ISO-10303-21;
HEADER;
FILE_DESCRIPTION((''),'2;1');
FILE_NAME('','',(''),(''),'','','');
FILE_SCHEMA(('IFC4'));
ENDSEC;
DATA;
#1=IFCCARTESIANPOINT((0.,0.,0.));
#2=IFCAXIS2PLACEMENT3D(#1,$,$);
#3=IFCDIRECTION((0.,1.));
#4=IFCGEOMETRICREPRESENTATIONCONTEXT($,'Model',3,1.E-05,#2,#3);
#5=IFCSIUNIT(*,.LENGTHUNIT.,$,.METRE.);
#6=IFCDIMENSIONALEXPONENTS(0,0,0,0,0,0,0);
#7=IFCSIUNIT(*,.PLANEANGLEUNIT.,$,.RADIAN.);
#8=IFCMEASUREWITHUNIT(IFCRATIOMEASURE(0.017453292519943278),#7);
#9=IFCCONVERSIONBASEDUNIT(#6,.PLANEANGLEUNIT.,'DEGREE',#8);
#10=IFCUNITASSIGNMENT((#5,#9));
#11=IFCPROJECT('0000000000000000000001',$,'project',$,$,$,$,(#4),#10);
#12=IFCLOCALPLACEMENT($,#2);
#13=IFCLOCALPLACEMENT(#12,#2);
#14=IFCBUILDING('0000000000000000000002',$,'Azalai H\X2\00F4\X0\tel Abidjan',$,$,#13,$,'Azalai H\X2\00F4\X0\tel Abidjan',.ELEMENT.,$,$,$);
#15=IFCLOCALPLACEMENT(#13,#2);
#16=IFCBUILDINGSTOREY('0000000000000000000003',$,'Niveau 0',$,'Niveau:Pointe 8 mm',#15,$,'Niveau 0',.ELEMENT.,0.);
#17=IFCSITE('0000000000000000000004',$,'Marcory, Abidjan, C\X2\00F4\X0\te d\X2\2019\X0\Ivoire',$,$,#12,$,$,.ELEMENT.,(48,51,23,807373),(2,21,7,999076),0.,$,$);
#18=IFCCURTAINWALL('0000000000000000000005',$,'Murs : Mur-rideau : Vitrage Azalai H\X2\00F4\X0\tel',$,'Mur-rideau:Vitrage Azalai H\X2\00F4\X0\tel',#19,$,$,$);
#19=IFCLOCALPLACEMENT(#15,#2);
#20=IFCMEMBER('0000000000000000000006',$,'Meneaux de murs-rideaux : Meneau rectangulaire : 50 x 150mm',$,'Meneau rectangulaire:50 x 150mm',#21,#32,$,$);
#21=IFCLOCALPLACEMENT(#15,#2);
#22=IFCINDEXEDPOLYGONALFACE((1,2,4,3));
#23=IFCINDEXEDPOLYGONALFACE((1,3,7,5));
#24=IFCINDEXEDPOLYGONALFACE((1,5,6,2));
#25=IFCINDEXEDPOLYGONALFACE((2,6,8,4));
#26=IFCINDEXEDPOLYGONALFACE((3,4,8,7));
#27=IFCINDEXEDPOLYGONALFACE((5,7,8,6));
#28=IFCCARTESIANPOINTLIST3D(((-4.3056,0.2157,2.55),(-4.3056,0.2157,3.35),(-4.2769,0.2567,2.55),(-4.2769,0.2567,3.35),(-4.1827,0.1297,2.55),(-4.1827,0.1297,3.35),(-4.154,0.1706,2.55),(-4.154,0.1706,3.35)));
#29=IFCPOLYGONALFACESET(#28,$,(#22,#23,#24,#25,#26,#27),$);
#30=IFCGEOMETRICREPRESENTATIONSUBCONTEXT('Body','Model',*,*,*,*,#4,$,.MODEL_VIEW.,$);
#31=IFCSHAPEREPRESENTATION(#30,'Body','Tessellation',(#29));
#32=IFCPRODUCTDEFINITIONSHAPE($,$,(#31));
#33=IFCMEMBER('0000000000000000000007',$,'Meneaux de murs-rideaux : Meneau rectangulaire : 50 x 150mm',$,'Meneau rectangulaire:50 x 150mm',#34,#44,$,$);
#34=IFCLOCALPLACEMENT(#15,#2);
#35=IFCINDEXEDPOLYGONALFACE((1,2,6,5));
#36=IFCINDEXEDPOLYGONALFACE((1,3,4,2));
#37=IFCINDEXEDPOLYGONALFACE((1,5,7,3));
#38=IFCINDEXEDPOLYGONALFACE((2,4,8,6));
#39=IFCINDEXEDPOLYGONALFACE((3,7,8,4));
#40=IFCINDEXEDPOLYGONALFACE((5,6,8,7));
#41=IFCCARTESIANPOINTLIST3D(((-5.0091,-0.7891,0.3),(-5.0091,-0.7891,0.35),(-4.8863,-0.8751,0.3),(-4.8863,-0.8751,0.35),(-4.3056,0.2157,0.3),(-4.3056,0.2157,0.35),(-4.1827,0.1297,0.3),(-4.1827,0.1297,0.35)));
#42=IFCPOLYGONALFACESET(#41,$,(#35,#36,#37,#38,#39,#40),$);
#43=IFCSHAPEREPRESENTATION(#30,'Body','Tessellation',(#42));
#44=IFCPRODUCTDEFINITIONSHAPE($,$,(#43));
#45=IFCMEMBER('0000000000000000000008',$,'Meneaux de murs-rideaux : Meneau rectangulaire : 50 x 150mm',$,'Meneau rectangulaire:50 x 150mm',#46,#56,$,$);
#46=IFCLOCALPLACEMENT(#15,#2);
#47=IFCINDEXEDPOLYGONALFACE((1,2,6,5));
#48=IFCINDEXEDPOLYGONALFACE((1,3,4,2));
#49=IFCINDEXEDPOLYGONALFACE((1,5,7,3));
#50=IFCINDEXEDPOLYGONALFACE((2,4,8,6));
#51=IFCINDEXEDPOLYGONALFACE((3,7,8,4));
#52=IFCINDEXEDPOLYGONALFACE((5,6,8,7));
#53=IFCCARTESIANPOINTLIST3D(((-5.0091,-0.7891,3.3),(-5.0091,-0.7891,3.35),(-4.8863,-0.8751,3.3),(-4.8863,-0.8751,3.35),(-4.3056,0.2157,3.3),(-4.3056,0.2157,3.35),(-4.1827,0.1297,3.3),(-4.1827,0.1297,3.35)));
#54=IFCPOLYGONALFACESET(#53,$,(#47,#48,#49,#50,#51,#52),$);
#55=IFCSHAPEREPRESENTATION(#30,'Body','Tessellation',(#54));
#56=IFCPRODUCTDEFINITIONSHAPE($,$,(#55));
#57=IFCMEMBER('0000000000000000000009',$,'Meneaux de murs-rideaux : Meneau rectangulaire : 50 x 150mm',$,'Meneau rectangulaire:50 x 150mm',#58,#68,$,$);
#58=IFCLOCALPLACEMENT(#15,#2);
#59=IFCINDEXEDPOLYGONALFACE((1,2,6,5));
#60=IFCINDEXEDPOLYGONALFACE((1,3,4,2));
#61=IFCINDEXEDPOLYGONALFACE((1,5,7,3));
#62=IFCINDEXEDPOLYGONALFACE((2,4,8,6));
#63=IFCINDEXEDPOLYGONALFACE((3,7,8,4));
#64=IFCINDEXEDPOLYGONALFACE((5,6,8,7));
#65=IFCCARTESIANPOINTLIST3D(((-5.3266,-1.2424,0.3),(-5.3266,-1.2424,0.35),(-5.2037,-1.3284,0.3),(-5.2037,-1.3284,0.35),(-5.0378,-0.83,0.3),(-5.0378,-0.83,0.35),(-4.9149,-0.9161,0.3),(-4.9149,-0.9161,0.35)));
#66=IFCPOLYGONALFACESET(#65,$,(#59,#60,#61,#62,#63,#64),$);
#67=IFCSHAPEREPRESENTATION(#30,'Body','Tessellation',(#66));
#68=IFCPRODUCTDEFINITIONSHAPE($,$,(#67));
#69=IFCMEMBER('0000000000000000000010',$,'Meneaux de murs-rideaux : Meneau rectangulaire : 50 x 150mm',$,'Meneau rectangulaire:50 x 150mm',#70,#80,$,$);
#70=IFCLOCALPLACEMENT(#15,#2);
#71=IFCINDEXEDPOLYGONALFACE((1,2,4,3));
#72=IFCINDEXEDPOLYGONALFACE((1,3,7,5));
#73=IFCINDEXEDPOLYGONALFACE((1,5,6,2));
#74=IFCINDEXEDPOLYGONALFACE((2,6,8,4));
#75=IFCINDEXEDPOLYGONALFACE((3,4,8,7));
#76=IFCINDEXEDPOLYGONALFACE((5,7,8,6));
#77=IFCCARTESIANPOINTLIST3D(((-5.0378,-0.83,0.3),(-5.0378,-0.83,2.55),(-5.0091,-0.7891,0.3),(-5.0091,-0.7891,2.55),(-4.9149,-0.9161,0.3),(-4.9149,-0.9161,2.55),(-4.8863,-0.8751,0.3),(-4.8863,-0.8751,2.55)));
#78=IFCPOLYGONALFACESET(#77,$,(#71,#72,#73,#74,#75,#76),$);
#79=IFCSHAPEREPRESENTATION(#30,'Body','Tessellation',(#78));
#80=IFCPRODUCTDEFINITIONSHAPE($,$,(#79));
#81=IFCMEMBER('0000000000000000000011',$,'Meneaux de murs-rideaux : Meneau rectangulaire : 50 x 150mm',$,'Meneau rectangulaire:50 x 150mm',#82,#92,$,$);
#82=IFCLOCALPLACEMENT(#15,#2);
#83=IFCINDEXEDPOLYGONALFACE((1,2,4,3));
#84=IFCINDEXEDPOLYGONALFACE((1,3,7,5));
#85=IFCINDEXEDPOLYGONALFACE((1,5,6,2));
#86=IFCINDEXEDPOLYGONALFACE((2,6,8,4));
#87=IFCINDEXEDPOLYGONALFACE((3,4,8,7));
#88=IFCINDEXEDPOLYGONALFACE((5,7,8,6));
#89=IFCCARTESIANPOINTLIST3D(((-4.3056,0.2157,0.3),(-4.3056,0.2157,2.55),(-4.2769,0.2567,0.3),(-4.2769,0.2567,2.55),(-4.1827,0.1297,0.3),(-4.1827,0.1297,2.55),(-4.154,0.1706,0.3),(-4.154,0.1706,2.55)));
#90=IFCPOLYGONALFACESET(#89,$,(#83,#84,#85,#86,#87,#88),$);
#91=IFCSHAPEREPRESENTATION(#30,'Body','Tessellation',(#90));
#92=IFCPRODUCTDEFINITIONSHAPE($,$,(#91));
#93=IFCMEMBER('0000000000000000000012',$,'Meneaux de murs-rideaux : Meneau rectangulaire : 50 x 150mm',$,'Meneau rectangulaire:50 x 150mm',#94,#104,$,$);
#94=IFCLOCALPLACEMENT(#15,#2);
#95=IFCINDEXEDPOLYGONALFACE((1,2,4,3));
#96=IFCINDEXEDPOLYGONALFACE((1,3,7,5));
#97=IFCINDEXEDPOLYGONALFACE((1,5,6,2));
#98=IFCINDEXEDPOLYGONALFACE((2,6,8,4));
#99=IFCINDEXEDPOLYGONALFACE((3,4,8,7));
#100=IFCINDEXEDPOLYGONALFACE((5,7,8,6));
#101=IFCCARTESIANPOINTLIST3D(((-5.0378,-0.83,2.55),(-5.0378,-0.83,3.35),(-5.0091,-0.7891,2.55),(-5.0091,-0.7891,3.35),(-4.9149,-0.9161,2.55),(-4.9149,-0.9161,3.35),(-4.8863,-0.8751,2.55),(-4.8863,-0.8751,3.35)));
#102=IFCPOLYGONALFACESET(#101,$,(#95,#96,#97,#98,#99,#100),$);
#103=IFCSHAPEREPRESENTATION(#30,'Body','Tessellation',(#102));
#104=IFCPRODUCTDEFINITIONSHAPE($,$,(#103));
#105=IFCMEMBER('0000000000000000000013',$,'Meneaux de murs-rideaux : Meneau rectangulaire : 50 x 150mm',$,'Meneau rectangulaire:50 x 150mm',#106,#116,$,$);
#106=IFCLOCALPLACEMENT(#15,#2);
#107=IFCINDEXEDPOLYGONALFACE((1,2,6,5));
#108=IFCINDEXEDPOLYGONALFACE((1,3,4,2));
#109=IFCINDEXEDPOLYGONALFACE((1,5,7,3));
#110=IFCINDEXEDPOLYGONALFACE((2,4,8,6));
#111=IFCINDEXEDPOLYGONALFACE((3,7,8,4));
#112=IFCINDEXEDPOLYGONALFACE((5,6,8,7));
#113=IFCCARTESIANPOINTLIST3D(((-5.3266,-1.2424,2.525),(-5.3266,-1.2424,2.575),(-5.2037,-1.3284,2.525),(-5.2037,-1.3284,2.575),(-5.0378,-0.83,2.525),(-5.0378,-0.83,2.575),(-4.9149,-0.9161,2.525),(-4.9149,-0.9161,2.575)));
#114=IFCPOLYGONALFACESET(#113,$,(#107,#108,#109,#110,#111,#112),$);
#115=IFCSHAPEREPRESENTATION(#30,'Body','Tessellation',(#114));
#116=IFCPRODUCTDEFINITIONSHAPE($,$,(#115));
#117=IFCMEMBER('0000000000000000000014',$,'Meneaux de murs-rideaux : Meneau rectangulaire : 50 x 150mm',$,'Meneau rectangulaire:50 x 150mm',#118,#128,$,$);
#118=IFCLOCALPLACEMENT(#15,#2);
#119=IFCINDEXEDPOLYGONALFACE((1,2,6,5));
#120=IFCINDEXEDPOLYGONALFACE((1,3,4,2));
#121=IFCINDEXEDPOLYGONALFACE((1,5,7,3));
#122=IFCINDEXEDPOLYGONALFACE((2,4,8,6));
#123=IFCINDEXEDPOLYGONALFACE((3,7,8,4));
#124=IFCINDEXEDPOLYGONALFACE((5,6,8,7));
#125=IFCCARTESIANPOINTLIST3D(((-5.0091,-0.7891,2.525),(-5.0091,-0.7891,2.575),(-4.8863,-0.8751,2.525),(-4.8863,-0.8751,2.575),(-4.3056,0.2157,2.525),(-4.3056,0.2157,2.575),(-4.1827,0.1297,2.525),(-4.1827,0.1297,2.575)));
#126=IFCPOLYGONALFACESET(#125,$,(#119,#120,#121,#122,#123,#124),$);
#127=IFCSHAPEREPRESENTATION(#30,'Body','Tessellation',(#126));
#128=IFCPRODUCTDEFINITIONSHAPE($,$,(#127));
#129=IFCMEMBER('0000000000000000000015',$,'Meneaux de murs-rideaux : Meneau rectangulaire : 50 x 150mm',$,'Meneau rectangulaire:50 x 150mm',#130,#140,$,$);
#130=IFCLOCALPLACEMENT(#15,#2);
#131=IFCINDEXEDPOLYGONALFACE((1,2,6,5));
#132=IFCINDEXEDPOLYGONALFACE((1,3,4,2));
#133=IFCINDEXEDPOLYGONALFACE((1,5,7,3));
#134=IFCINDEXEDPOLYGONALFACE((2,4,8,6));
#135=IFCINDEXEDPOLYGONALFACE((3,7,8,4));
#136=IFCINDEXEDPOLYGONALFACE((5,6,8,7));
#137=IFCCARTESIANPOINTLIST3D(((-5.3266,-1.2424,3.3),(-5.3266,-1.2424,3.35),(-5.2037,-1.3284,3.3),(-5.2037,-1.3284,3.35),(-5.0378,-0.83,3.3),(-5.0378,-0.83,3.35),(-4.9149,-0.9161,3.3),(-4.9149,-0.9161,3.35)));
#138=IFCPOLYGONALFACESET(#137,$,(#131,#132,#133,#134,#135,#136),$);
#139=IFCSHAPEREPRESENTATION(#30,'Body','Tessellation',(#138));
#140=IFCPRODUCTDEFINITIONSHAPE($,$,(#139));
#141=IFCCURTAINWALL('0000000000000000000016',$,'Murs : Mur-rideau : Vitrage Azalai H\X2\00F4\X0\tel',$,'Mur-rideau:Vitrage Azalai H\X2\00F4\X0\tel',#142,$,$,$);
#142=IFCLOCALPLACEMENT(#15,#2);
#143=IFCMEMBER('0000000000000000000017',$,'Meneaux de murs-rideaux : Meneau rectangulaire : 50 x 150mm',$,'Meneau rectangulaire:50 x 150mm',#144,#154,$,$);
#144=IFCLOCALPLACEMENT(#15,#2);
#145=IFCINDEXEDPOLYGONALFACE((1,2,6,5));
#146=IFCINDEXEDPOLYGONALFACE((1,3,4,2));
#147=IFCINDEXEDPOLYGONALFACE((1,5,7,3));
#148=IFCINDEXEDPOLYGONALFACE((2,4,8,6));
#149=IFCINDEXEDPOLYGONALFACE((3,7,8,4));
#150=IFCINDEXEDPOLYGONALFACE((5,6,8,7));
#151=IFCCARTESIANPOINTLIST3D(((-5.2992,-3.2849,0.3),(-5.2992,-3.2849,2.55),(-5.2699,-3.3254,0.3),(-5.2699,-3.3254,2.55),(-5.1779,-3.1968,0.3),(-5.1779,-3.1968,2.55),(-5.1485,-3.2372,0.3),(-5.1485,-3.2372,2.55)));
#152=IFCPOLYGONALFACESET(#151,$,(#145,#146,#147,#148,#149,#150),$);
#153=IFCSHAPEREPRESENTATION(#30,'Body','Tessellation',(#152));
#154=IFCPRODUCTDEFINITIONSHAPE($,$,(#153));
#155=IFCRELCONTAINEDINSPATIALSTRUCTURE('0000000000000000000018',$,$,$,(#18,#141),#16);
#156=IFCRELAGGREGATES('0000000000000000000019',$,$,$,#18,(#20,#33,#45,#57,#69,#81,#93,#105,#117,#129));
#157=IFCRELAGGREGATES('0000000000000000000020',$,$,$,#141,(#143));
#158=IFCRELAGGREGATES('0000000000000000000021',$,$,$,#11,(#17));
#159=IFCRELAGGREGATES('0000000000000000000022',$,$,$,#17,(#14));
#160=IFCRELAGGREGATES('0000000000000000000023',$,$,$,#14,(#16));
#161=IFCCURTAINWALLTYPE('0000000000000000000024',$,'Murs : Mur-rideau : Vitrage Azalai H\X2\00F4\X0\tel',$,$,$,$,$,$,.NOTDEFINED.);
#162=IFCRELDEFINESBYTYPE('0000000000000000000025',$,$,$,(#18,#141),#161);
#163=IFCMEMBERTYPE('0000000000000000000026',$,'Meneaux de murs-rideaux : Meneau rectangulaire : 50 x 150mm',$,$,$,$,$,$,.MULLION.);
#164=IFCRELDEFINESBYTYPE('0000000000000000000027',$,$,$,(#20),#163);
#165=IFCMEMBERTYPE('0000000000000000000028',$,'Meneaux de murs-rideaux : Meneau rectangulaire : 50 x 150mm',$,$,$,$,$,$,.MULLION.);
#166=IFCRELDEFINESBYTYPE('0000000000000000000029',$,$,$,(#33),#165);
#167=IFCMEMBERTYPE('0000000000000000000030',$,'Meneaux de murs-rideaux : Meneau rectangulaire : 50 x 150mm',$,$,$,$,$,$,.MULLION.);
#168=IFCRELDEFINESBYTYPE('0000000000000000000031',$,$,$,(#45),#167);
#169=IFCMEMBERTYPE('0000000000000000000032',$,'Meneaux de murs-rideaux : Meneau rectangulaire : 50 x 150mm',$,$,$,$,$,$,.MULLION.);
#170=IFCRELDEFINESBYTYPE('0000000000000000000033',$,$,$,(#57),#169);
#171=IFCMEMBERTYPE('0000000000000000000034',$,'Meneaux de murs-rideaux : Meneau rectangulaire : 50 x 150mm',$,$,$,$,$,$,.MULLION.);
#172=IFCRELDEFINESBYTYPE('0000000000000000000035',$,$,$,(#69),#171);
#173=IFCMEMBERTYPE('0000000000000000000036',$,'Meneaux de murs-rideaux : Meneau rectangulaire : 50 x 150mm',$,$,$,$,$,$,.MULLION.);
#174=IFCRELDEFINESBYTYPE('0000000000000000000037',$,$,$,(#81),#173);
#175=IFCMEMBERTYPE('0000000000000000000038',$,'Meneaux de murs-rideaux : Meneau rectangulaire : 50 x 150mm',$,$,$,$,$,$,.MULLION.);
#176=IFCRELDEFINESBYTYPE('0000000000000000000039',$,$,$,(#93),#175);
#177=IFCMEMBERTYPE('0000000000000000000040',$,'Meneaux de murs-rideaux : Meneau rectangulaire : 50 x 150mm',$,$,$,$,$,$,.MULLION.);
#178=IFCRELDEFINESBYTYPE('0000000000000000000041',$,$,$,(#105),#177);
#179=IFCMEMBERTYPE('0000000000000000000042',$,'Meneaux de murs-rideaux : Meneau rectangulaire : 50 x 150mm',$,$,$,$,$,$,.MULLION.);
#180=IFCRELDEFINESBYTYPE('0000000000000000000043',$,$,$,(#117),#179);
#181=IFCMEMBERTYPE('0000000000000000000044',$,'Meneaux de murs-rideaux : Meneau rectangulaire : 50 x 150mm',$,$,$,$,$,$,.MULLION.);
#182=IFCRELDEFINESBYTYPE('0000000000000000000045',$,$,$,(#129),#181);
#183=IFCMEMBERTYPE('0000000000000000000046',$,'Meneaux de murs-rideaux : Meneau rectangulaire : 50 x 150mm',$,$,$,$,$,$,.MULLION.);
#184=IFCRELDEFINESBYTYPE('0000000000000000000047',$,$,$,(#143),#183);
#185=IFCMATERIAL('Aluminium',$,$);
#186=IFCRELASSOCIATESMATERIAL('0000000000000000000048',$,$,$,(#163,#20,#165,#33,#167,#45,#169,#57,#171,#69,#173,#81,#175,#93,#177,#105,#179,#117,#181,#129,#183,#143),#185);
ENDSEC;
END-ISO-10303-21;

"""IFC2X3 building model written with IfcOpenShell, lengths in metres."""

from ifc_helpers import new_model, entity, si_unit, converted_unit, direction, frame, origin, origin_2d_with_axis, place, context, subcontext, project, spatial, rectangle, extrude, source, transform, mapped, material, type_object, type_shapes, element, aggregate, save


model = new_model("IFC2X3")

# Units and contexts
model_context = context("Model", 3, precision=1e-05, world=origin(), true_north=direction((0.0, 1.0)))
body_context = subcontext(model_context, "Body", "Model", "MODEL_VIEW")
ifc_project = project(units=[si_unit("LENGTHUNIT", "METRE"), converted_unit("PLANEANGLEUNIT", "DEGREE", entity("IfcRatioMeasure", 0.017453292519943278), si_unit("PLANEANGLEUNIT", "RADIAN"), dimensions=[0, 0, 0, 0, 0, 0, 0])], contexts=[model_context])

# Site, building, storey
site_placement = place(None, origin())
site = spatial("IfcSite", under=ifc_project, at=site_placement, Name="Marcory, Abidjan, Côte d’Ivoire", CompositionType="ELEMENT", RefLatitude=(48, 51, 23, 807373), RefLongitude=(2, 21, 7, 999076), RefElevation=0.0)
building_placement = place(site_placement, origin())
building = spatial("IfcBuilding", under=site, at=building_placement, Name="Azalai Hôtel Abidjan", LongName="Azalai Hôtel Abidjan", CompositionType="ELEMENT")
storey_placement = place(building_placement, origin())
storey = spatial("IfcBuildingStorey", under=building, at=storey_placement, Name="Niveau 0", ObjectType="Niveau:Pointe 8 mm", LongName="Niveau 0", CompositionType="ELEMENT", Elevation=0.0)

# Curtain walls, members
curtain_wall_type = type_object("IfcCurtainWallType", Name="Murs : Mur-rideau : Vitrage Azalai Hôtel", PredefinedType="NOTDEFINED")
curtain_wall_1_placement = place(storey_placement, origin())
curtain_wall_1 = element("IfcCurtainWall", 1, at=curtain_wall_1_placement, inside=storey, type_object=curtain_wall_type, Name="Murs : Mur-rideau : Vitrage Azalai Hôtel", ObjectType="Mur-rideau:Vitrage Azalai Hôtel")
ifc_material_1 = material(Name="Aluminium")
member_type_1 = type_object("IfcMemberType", Name="Meneaux de murs-rideaux : Meneau rectangulaire : 50 x 150mm", PredefinedType="MULLION", material=ifc_material_1)
shared_shape_1 = source(origin(), body_context, "Body", "SweptSolid", [
    extrude(rectangle(XDim=0.15, YDim=0.05, at=origin_2d_with_axis()), frame((-0.025, 0.0, -0.8), z_axis=(0.0, 0.0, 1.0), x_axis=(0.0, -1.0, 0.0)), (0.0, 0.0, 1.0), 0.8),
])
type_shapes(member_type_1, [shared_shape_1])
member_1_placement = place(curtain_wall_1_placement, frame((-4.2155, 0.2136, 3.35), z_axis=(0.0, 0.0, 1.0), x_axis=(0.573576, 0.819152, 0.0)))
member_1 = element("IfcMember", 2, at=member_1_placement, type_object=member_type_1, material=ifc_material_1, Name="Meneaux de murs-rideaux : Meneau rectangulaire : 50 x 150mm", ObjectType="Meneau rectangulaire:50 x 150mm", context=body_context, shape_type="MappedRepresentation", body=[
    mapped(shared_shape_1, transform((0.0, 0.0, 0.0), scale=1.0)),
])
member_type_2 = type_object("IfcMemberType", Name="Meneaux de murs-rideaux : Meneau rectangulaire : 50 x 150mm", PredefinedType="MULLION", material=ifc_material_1)
shared_shape_2 = source(origin(), body_context, "Body", "SweptSolid", [
    extrude(rectangle(XDim=0.15, YDim=0.05, at=origin_2d_with_axis()), frame((-0.025, 0.0, -1.2266), z_axis=(0.0, 0.0, 1.0), x_axis=(0.0, -1.0, 0.0)), (0.0, 0.0, 1.0), 1.2266),
])
type_shapes(member_type_2, [shared_shape_2])
member_2_placement = place(curtain_wall_1_placement, frame((-4.2441, 0.1727, 0.3), z_axis=(0.573576, 0.819152, 0.0), x_axis=(0.0, 0.0, -1.0)))
member_2 = element("IfcMember", 3, at=member_2_placement, type_object=member_type_2, material=ifc_material_1, Name="Meneaux de murs-rideaux : Meneau rectangulaire : 50 x 150mm", ObjectType="Meneau rectangulaire:50 x 150mm", context=body_context, shape_type="MappedRepresentation", body=[
    mapped(shared_shape_2, transform((0.0, 0.0, 0.0), scale=1.0)),
])
member_type_3 = type_object("IfcMemberType", Name="Meneaux de murs-rideaux : Meneau rectangulaire : 50 x 150mm", PredefinedType="MULLION", material=ifc_material_1)
shared_shape_3 = source(origin(), body_context, "Body", "SweptSolid", [
    extrude(rectangle(XDim=0.15, YDim=0.05, at=origin_2d_with_axis()), frame((-0.025, 0.0, -1.2266), z_axis=(0.0, 0.0, 1.0), x_axis=(0.0, -1.0, 0.0)), (0.0, 0.0, 1.0), 1.2266),
])
type_shapes(member_type_3, [shared_shape_3])
member_3_placement = place(curtain_wall_1_placement, frame((-4.9477, -0.8321, 3.35), z_axis=(-0.573576, -0.819152, 0.0), x_axis=(0.0, 0.0, 1.0)))
member_3 = element("IfcMember", 4, at=member_3_placement, type_object=member_type_3, material=ifc_material_1, Name="Meneaux de murs-rideaux : Meneau rectangulaire : 50 x 150mm", ObjectType="Meneau rectangulaire:50 x 150mm", context=body_context, shape_type="MappedRepresentation", body=[
    mapped(shared_shape_3, transform((0.0, 0.0, 0.0), scale=1.0)),
])
member_type_4 = type_object("IfcMemberType", Name="Meneaux de murs-rideaux : Meneau rectangulaire : 50 x 150mm", PredefinedType="MULLION", material=ifc_material_1)
shared_shape_4 = source(origin(), body_context, "Body", "SweptSolid", [
    extrude(rectangle(XDim=0.15, YDim=0.05, at=origin_2d_with_axis()), frame((-0.025, 0.0, -0.5034), z_axis=(0.0, 0.0, 1.0), x_axis=(0.0, -1.0, 0.0)), (0.0, 0.0, 1.0), 0.5034),
])
type_shapes(member_type_4, [shared_shape_4])
member_4_placement = place(curtain_wall_1_placement, frame((-4.9764, -0.873, 0.3), z_axis=(0.573576, 0.819152, 0.0), x_axis=(0.0, 0.0, -1.0)))
member_4 = element("IfcMember", 5, at=member_4_placement, type_object=member_type_4, material=ifc_material_1, Name="Meneaux de murs-rideaux : Meneau rectangulaire : 50 x 150mm", ObjectType="Meneau rectangulaire:50 x 150mm", context=body_context, shape_type="MappedRepresentation", body=[
    mapped(shared_shape_4, transform((0.0, 0.0, 0.0), scale=1.0)),
])
member_type_5 = type_object("IfcMemberType", Name="Meneaux de murs-rideaux : Meneau rectangulaire : 50 x 150mm", PredefinedType="MULLION", material=ifc_material_1)
shared_shape_5 = source(origin(), body_context, "Body", "SweptSolid", [
    extrude(rectangle(XDim=0.15, YDim=0.05, at=origin_2d_with_axis()), frame((0.0, 0.0, -2.25), z_axis=(0.0, 0.0, 1.0), x_axis=(0.0, -1.0, 0.0)), (0.0, 0.0, 1.0), 2.25),
])
type_shapes(member_type_5, [shared_shape_5])
member_5_placement = place(curtain_wall_1_placement, frame((-4.962, -0.8526, 0.3), z_axis=(0.0, 0.0, -1.0), x_axis=(-0.573576, -0.819152, 0.0)))
member_5 = element("IfcMember", 6, at=member_5_placement, type_object=member_type_5, material=ifc_material_1, Name="Meneaux de murs-rideaux : Meneau rectangulaire : 50 x 150mm", ObjectType="Meneau rectangulaire:50 x 150mm", context=body_context, shape_type="MappedRepresentation", body=[
    mapped(shared_shape_5, transform((0.0, 0.0, 0.0), scale=1.0)),
])
member_type_6 = type_object("IfcMemberType", Name="Meneaux de murs-rideaux : Meneau rectangulaire : 50 x 150mm", PredefinedType="MULLION", material=ifc_material_1)
shared_shape_6 = source(origin(), body_context, "Body", "SweptSolid", [
    extrude(rectangle(XDim=0.15, YDim=0.05, at=origin_2d_with_axis()), frame((-0.025, 0.0, -2.25), z_axis=(0.0, 0.0, 1.0), x_axis=(0.0, -1.0, 0.0)), (0.0, 0.0, 1.0), 2.25),
])
type_shapes(member_type_6, [shared_shape_6])
member_6_placement = place(curtain_wall_1_placement, frame((-4.2155, 0.2136, 2.55), z_axis=(0.0, 0.0, 1.0), x_axis=(0.573576, 0.819152, 0.0)))
member_6 = element("IfcMember", 7, at=member_6_placement, type_object=member_type_6, material=ifc_material_1, Name="Meneaux de murs-rideaux : Meneau rectangulaire : 50 x 150mm", ObjectType="Meneau rectangulaire:50 x 150mm", context=body_context, shape_type="MappedRepresentation", body=[
    mapped(shared_shape_6, transform((0.0, 0.0, 0.0), scale=1.0)),
])
member_type_7 = type_object("IfcMemberType", Name="Meneaux de murs-rideaux : Meneau rectangulaire : 50 x 150mm", PredefinedType="MULLION", material=ifc_material_1)
shared_shape_7 = source(origin(), body_context, "Body", "SweptSolid", [
    extrude(rectangle(XDim=0.15, YDim=0.05, at=origin_2d_with_axis()), frame((0.0, 0.0, -0.8), z_axis=(0.0, 0.0, 1.0), x_axis=(0.0, -1.0, 0.0)), (0.0, 0.0, 1.0), 0.8),
])
type_shapes(member_type_7, [shared_shape_7])
member_7_placement = place(curtain_wall_1_placement, frame((-4.962, -0.8526, 2.55), z_axis=(0.0, 0.0, -1.0), x_axis=(-0.573576, -0.819152, 0.0)))
member_7 = element("IfcMember", 8, at=member_7_placement, type_object=member_type_7, material=ifc_material_1, Name="Meneaux de murs-rideaux : Meneau rectangulaire : 50 x 150mm", ObjectType="Meneau rectangulaire:50 x 150mm", context=body_context, shape_type="MappedRepresentation", body=[
    mapped(shared_shape_7, transform((0.0, 0.0, 0.0), scale=1.0)),
])
member_type_8 = type_object("IfcMemberType", Name="Meneaux de murs-rideaux : Meneau rectangulaire : 50 x 150mm", PredefinedType="MULLION", material=ifc_material_1)
shared_shape_8 = source(origin(), body_context, "Body", "SweptSolid", [
    extrude(rectangle(XDim=0.15, YDim=0.05, at=origin_2d_with_axis()), frame((0.0, 0.0, -0.5034), z_axis=(0.0, 0.0, 1.0), x_axis=(0.0, -1.0, 0.0)), (0.0, 0.0, 1.0), 0.5034),
])
type_shapes(member_type_8, [shared_shape_8])
member_8_placement = place(curtain_wall_1_placement, frame((-5.2651, -1.2854, 2.55), z_axis=(-0.573576, -0.819152, 0.0), x_axis=(0.0, 0.0, 1.0)))
member_8 = element("IfcMember", 9, at=member_8_placement, type_object=member_type_8, material=ifc_material_1, Name="Meneaux de murs-rideaux : Meneau rectangulaire : 50 x 150mm", ObjectType="Meneau rectangulaire:50 x 150mm", context=body_context, shape_type="MappedRepresentation", body=[
    mapped(shared_shape_8, transform((0.0, 0.0, 0.0), scale=1.0)),
])
member_type_9 = type_object("IfcMemberType", Name="Meneaux de murs-rideaux : Meneau rectangulaire : 50 x 150mm", PredefinedType="MULLION", material=ifc_material_1)
shared_shape_9 = source(origin(), body_context, "Body", "SweptSolid", [
    extrude(rectangle(XDim=0.15, YDim=0.05, at=origin_2d_with_axis()), frame((0.0, 0.0, -1.2266), z_axis=(0.0, 0.0, 1.0), x_axis=(0.0, -1.0, 0.0)), (0.0, 0.0, 1.0), 1.2266),
])
type_shapes(member_type_9, [shared_shape_9])
member_9_placement = place(curtain_wall_1_placement, frame((-4.9477, -0.8321, 2.55), z_axis=(-0.573576, -0.819152, 0.0), x_axis=(0.0, 0.0, 1.0)))
member_9 = element("IfcMember", 10, at=member_9_placement, type_object=member_type_9, material=ifc_material_1, Name="Meneaux de murs-rideaux : Meneau rectangulaire : 50 x 150mm", ObjectType="Meneau rectangulaire:50 x 150mm", context=body_context, shape_type="MappedRepresentation", body=[
    mapped(shared_shape_9, transform((0.0, 0.0, 0.0), scale=1.0)),
])
member_type_10 = type_object("IfcMemberType", Name="Meneaux de murs-rideaux : Meneau rectangulaire : 50 x 150mm", PredefinedType="MULLION", material=ifc_material_1)
shared_shape_10 = source(origin(), body_context, "Body", "SweptSolid", [
    extrude(rectangle(XDim=0.15, YDim=0.05, at=origin_2d_with_axis()), frame((-0.025, 0.0, -0.5034), z_axis=(0.0, 0.0, 1.0), x_axis=(0.0, -1.0, 0.0)), (0.0, 0.0, 1.0), 0.5034),
])
type_shapes(member_type_10, [shared_shape_10])
member_10_placement = place(curtain_wall_1_placement, frame((-5.2651, -1.2854, 3.35), z_axis=(-0.573576, -0.819152, 0.0), x_axis=(0.0, 0.0, 1.0)))
member_10 = element("IfcMember", 11, at=member_10_placement, type_object=member_type_10, material=ifc_material_1, Name="Meneaux de murs-rideaux : Meneau rectangulaire : 50 x 150mm", ObjectType="Meneau rectangulaire:50 x 150mm", context=body_context, shape_type="MappedRepresentation", body=[
    mapped(shared_shape_10, transform((0.0, 0.0, 0.0), scale=1.0)),
])
curtain_wall_2_placement = place(storey_placement, origin())
curtain_wall_2 = element("IfcCurtainWall", 12, at=curtain_wall_2_placement, inside=storey, type_object=curtain_wall_type, Name="Murs : Mur-rideau : Vitrage Azalai Hôtel", ObjectType="Mur-rideau:Vitrage Azalai Hôtel")
member_type_11 = type_object("IfcMemberType", Name="Meneaux de murs-rideaux : Meneau rectangulaire : 50 x 150mm", PredefinedType="MULLION", material=ifc_material_1)
shared_shape_11 = source(origin(), body_context, "Body", "SweptSolid", [
    extrude(rectangle(XDim=0.15, YDim=0.05, at=origin_2d_with_axis()), frame((-0.025, 0.0, -2.25), z_axis=(0.0, 0.0, 1.0), x_axis=(0.0, -1.0, 0.0)), (0.0, 0.0, 1.0), 2.25),
])
type_shapes(member_type_11, [shared_shape_11])
member_11_placement = place(curtain_wall_2_placement, frame((-5.2092, -3.2813, 0.3), z_axis=(0.0, 0.0, -1.0), x_axis=(0.587785, -0.809017, 0.0)))
member_11 = element("IfcMember", 13, at=member_11_placement, type_object=member_type_11, material=ifc_material_1, Name="Meneaux de murs-rideaux : Meneau rectangulaire : 50 x 150mm", ObjectType="Meneau rectangulaire:50 x 150mm", context=body_context, shape_type="MappedRepresentation", body=[
    mapped(shared_shape_11, transform((0.0, 0.0, 0.0), scale=1.0)),
])

aggregate(curtain_wall_1, [member_1, member_2, member_3, member_4, member_5, member_6, member_7, member_8, member_9, member_10])
aggregate(curtain_wall_2, [member_11])

save(model, "model.ifc")
